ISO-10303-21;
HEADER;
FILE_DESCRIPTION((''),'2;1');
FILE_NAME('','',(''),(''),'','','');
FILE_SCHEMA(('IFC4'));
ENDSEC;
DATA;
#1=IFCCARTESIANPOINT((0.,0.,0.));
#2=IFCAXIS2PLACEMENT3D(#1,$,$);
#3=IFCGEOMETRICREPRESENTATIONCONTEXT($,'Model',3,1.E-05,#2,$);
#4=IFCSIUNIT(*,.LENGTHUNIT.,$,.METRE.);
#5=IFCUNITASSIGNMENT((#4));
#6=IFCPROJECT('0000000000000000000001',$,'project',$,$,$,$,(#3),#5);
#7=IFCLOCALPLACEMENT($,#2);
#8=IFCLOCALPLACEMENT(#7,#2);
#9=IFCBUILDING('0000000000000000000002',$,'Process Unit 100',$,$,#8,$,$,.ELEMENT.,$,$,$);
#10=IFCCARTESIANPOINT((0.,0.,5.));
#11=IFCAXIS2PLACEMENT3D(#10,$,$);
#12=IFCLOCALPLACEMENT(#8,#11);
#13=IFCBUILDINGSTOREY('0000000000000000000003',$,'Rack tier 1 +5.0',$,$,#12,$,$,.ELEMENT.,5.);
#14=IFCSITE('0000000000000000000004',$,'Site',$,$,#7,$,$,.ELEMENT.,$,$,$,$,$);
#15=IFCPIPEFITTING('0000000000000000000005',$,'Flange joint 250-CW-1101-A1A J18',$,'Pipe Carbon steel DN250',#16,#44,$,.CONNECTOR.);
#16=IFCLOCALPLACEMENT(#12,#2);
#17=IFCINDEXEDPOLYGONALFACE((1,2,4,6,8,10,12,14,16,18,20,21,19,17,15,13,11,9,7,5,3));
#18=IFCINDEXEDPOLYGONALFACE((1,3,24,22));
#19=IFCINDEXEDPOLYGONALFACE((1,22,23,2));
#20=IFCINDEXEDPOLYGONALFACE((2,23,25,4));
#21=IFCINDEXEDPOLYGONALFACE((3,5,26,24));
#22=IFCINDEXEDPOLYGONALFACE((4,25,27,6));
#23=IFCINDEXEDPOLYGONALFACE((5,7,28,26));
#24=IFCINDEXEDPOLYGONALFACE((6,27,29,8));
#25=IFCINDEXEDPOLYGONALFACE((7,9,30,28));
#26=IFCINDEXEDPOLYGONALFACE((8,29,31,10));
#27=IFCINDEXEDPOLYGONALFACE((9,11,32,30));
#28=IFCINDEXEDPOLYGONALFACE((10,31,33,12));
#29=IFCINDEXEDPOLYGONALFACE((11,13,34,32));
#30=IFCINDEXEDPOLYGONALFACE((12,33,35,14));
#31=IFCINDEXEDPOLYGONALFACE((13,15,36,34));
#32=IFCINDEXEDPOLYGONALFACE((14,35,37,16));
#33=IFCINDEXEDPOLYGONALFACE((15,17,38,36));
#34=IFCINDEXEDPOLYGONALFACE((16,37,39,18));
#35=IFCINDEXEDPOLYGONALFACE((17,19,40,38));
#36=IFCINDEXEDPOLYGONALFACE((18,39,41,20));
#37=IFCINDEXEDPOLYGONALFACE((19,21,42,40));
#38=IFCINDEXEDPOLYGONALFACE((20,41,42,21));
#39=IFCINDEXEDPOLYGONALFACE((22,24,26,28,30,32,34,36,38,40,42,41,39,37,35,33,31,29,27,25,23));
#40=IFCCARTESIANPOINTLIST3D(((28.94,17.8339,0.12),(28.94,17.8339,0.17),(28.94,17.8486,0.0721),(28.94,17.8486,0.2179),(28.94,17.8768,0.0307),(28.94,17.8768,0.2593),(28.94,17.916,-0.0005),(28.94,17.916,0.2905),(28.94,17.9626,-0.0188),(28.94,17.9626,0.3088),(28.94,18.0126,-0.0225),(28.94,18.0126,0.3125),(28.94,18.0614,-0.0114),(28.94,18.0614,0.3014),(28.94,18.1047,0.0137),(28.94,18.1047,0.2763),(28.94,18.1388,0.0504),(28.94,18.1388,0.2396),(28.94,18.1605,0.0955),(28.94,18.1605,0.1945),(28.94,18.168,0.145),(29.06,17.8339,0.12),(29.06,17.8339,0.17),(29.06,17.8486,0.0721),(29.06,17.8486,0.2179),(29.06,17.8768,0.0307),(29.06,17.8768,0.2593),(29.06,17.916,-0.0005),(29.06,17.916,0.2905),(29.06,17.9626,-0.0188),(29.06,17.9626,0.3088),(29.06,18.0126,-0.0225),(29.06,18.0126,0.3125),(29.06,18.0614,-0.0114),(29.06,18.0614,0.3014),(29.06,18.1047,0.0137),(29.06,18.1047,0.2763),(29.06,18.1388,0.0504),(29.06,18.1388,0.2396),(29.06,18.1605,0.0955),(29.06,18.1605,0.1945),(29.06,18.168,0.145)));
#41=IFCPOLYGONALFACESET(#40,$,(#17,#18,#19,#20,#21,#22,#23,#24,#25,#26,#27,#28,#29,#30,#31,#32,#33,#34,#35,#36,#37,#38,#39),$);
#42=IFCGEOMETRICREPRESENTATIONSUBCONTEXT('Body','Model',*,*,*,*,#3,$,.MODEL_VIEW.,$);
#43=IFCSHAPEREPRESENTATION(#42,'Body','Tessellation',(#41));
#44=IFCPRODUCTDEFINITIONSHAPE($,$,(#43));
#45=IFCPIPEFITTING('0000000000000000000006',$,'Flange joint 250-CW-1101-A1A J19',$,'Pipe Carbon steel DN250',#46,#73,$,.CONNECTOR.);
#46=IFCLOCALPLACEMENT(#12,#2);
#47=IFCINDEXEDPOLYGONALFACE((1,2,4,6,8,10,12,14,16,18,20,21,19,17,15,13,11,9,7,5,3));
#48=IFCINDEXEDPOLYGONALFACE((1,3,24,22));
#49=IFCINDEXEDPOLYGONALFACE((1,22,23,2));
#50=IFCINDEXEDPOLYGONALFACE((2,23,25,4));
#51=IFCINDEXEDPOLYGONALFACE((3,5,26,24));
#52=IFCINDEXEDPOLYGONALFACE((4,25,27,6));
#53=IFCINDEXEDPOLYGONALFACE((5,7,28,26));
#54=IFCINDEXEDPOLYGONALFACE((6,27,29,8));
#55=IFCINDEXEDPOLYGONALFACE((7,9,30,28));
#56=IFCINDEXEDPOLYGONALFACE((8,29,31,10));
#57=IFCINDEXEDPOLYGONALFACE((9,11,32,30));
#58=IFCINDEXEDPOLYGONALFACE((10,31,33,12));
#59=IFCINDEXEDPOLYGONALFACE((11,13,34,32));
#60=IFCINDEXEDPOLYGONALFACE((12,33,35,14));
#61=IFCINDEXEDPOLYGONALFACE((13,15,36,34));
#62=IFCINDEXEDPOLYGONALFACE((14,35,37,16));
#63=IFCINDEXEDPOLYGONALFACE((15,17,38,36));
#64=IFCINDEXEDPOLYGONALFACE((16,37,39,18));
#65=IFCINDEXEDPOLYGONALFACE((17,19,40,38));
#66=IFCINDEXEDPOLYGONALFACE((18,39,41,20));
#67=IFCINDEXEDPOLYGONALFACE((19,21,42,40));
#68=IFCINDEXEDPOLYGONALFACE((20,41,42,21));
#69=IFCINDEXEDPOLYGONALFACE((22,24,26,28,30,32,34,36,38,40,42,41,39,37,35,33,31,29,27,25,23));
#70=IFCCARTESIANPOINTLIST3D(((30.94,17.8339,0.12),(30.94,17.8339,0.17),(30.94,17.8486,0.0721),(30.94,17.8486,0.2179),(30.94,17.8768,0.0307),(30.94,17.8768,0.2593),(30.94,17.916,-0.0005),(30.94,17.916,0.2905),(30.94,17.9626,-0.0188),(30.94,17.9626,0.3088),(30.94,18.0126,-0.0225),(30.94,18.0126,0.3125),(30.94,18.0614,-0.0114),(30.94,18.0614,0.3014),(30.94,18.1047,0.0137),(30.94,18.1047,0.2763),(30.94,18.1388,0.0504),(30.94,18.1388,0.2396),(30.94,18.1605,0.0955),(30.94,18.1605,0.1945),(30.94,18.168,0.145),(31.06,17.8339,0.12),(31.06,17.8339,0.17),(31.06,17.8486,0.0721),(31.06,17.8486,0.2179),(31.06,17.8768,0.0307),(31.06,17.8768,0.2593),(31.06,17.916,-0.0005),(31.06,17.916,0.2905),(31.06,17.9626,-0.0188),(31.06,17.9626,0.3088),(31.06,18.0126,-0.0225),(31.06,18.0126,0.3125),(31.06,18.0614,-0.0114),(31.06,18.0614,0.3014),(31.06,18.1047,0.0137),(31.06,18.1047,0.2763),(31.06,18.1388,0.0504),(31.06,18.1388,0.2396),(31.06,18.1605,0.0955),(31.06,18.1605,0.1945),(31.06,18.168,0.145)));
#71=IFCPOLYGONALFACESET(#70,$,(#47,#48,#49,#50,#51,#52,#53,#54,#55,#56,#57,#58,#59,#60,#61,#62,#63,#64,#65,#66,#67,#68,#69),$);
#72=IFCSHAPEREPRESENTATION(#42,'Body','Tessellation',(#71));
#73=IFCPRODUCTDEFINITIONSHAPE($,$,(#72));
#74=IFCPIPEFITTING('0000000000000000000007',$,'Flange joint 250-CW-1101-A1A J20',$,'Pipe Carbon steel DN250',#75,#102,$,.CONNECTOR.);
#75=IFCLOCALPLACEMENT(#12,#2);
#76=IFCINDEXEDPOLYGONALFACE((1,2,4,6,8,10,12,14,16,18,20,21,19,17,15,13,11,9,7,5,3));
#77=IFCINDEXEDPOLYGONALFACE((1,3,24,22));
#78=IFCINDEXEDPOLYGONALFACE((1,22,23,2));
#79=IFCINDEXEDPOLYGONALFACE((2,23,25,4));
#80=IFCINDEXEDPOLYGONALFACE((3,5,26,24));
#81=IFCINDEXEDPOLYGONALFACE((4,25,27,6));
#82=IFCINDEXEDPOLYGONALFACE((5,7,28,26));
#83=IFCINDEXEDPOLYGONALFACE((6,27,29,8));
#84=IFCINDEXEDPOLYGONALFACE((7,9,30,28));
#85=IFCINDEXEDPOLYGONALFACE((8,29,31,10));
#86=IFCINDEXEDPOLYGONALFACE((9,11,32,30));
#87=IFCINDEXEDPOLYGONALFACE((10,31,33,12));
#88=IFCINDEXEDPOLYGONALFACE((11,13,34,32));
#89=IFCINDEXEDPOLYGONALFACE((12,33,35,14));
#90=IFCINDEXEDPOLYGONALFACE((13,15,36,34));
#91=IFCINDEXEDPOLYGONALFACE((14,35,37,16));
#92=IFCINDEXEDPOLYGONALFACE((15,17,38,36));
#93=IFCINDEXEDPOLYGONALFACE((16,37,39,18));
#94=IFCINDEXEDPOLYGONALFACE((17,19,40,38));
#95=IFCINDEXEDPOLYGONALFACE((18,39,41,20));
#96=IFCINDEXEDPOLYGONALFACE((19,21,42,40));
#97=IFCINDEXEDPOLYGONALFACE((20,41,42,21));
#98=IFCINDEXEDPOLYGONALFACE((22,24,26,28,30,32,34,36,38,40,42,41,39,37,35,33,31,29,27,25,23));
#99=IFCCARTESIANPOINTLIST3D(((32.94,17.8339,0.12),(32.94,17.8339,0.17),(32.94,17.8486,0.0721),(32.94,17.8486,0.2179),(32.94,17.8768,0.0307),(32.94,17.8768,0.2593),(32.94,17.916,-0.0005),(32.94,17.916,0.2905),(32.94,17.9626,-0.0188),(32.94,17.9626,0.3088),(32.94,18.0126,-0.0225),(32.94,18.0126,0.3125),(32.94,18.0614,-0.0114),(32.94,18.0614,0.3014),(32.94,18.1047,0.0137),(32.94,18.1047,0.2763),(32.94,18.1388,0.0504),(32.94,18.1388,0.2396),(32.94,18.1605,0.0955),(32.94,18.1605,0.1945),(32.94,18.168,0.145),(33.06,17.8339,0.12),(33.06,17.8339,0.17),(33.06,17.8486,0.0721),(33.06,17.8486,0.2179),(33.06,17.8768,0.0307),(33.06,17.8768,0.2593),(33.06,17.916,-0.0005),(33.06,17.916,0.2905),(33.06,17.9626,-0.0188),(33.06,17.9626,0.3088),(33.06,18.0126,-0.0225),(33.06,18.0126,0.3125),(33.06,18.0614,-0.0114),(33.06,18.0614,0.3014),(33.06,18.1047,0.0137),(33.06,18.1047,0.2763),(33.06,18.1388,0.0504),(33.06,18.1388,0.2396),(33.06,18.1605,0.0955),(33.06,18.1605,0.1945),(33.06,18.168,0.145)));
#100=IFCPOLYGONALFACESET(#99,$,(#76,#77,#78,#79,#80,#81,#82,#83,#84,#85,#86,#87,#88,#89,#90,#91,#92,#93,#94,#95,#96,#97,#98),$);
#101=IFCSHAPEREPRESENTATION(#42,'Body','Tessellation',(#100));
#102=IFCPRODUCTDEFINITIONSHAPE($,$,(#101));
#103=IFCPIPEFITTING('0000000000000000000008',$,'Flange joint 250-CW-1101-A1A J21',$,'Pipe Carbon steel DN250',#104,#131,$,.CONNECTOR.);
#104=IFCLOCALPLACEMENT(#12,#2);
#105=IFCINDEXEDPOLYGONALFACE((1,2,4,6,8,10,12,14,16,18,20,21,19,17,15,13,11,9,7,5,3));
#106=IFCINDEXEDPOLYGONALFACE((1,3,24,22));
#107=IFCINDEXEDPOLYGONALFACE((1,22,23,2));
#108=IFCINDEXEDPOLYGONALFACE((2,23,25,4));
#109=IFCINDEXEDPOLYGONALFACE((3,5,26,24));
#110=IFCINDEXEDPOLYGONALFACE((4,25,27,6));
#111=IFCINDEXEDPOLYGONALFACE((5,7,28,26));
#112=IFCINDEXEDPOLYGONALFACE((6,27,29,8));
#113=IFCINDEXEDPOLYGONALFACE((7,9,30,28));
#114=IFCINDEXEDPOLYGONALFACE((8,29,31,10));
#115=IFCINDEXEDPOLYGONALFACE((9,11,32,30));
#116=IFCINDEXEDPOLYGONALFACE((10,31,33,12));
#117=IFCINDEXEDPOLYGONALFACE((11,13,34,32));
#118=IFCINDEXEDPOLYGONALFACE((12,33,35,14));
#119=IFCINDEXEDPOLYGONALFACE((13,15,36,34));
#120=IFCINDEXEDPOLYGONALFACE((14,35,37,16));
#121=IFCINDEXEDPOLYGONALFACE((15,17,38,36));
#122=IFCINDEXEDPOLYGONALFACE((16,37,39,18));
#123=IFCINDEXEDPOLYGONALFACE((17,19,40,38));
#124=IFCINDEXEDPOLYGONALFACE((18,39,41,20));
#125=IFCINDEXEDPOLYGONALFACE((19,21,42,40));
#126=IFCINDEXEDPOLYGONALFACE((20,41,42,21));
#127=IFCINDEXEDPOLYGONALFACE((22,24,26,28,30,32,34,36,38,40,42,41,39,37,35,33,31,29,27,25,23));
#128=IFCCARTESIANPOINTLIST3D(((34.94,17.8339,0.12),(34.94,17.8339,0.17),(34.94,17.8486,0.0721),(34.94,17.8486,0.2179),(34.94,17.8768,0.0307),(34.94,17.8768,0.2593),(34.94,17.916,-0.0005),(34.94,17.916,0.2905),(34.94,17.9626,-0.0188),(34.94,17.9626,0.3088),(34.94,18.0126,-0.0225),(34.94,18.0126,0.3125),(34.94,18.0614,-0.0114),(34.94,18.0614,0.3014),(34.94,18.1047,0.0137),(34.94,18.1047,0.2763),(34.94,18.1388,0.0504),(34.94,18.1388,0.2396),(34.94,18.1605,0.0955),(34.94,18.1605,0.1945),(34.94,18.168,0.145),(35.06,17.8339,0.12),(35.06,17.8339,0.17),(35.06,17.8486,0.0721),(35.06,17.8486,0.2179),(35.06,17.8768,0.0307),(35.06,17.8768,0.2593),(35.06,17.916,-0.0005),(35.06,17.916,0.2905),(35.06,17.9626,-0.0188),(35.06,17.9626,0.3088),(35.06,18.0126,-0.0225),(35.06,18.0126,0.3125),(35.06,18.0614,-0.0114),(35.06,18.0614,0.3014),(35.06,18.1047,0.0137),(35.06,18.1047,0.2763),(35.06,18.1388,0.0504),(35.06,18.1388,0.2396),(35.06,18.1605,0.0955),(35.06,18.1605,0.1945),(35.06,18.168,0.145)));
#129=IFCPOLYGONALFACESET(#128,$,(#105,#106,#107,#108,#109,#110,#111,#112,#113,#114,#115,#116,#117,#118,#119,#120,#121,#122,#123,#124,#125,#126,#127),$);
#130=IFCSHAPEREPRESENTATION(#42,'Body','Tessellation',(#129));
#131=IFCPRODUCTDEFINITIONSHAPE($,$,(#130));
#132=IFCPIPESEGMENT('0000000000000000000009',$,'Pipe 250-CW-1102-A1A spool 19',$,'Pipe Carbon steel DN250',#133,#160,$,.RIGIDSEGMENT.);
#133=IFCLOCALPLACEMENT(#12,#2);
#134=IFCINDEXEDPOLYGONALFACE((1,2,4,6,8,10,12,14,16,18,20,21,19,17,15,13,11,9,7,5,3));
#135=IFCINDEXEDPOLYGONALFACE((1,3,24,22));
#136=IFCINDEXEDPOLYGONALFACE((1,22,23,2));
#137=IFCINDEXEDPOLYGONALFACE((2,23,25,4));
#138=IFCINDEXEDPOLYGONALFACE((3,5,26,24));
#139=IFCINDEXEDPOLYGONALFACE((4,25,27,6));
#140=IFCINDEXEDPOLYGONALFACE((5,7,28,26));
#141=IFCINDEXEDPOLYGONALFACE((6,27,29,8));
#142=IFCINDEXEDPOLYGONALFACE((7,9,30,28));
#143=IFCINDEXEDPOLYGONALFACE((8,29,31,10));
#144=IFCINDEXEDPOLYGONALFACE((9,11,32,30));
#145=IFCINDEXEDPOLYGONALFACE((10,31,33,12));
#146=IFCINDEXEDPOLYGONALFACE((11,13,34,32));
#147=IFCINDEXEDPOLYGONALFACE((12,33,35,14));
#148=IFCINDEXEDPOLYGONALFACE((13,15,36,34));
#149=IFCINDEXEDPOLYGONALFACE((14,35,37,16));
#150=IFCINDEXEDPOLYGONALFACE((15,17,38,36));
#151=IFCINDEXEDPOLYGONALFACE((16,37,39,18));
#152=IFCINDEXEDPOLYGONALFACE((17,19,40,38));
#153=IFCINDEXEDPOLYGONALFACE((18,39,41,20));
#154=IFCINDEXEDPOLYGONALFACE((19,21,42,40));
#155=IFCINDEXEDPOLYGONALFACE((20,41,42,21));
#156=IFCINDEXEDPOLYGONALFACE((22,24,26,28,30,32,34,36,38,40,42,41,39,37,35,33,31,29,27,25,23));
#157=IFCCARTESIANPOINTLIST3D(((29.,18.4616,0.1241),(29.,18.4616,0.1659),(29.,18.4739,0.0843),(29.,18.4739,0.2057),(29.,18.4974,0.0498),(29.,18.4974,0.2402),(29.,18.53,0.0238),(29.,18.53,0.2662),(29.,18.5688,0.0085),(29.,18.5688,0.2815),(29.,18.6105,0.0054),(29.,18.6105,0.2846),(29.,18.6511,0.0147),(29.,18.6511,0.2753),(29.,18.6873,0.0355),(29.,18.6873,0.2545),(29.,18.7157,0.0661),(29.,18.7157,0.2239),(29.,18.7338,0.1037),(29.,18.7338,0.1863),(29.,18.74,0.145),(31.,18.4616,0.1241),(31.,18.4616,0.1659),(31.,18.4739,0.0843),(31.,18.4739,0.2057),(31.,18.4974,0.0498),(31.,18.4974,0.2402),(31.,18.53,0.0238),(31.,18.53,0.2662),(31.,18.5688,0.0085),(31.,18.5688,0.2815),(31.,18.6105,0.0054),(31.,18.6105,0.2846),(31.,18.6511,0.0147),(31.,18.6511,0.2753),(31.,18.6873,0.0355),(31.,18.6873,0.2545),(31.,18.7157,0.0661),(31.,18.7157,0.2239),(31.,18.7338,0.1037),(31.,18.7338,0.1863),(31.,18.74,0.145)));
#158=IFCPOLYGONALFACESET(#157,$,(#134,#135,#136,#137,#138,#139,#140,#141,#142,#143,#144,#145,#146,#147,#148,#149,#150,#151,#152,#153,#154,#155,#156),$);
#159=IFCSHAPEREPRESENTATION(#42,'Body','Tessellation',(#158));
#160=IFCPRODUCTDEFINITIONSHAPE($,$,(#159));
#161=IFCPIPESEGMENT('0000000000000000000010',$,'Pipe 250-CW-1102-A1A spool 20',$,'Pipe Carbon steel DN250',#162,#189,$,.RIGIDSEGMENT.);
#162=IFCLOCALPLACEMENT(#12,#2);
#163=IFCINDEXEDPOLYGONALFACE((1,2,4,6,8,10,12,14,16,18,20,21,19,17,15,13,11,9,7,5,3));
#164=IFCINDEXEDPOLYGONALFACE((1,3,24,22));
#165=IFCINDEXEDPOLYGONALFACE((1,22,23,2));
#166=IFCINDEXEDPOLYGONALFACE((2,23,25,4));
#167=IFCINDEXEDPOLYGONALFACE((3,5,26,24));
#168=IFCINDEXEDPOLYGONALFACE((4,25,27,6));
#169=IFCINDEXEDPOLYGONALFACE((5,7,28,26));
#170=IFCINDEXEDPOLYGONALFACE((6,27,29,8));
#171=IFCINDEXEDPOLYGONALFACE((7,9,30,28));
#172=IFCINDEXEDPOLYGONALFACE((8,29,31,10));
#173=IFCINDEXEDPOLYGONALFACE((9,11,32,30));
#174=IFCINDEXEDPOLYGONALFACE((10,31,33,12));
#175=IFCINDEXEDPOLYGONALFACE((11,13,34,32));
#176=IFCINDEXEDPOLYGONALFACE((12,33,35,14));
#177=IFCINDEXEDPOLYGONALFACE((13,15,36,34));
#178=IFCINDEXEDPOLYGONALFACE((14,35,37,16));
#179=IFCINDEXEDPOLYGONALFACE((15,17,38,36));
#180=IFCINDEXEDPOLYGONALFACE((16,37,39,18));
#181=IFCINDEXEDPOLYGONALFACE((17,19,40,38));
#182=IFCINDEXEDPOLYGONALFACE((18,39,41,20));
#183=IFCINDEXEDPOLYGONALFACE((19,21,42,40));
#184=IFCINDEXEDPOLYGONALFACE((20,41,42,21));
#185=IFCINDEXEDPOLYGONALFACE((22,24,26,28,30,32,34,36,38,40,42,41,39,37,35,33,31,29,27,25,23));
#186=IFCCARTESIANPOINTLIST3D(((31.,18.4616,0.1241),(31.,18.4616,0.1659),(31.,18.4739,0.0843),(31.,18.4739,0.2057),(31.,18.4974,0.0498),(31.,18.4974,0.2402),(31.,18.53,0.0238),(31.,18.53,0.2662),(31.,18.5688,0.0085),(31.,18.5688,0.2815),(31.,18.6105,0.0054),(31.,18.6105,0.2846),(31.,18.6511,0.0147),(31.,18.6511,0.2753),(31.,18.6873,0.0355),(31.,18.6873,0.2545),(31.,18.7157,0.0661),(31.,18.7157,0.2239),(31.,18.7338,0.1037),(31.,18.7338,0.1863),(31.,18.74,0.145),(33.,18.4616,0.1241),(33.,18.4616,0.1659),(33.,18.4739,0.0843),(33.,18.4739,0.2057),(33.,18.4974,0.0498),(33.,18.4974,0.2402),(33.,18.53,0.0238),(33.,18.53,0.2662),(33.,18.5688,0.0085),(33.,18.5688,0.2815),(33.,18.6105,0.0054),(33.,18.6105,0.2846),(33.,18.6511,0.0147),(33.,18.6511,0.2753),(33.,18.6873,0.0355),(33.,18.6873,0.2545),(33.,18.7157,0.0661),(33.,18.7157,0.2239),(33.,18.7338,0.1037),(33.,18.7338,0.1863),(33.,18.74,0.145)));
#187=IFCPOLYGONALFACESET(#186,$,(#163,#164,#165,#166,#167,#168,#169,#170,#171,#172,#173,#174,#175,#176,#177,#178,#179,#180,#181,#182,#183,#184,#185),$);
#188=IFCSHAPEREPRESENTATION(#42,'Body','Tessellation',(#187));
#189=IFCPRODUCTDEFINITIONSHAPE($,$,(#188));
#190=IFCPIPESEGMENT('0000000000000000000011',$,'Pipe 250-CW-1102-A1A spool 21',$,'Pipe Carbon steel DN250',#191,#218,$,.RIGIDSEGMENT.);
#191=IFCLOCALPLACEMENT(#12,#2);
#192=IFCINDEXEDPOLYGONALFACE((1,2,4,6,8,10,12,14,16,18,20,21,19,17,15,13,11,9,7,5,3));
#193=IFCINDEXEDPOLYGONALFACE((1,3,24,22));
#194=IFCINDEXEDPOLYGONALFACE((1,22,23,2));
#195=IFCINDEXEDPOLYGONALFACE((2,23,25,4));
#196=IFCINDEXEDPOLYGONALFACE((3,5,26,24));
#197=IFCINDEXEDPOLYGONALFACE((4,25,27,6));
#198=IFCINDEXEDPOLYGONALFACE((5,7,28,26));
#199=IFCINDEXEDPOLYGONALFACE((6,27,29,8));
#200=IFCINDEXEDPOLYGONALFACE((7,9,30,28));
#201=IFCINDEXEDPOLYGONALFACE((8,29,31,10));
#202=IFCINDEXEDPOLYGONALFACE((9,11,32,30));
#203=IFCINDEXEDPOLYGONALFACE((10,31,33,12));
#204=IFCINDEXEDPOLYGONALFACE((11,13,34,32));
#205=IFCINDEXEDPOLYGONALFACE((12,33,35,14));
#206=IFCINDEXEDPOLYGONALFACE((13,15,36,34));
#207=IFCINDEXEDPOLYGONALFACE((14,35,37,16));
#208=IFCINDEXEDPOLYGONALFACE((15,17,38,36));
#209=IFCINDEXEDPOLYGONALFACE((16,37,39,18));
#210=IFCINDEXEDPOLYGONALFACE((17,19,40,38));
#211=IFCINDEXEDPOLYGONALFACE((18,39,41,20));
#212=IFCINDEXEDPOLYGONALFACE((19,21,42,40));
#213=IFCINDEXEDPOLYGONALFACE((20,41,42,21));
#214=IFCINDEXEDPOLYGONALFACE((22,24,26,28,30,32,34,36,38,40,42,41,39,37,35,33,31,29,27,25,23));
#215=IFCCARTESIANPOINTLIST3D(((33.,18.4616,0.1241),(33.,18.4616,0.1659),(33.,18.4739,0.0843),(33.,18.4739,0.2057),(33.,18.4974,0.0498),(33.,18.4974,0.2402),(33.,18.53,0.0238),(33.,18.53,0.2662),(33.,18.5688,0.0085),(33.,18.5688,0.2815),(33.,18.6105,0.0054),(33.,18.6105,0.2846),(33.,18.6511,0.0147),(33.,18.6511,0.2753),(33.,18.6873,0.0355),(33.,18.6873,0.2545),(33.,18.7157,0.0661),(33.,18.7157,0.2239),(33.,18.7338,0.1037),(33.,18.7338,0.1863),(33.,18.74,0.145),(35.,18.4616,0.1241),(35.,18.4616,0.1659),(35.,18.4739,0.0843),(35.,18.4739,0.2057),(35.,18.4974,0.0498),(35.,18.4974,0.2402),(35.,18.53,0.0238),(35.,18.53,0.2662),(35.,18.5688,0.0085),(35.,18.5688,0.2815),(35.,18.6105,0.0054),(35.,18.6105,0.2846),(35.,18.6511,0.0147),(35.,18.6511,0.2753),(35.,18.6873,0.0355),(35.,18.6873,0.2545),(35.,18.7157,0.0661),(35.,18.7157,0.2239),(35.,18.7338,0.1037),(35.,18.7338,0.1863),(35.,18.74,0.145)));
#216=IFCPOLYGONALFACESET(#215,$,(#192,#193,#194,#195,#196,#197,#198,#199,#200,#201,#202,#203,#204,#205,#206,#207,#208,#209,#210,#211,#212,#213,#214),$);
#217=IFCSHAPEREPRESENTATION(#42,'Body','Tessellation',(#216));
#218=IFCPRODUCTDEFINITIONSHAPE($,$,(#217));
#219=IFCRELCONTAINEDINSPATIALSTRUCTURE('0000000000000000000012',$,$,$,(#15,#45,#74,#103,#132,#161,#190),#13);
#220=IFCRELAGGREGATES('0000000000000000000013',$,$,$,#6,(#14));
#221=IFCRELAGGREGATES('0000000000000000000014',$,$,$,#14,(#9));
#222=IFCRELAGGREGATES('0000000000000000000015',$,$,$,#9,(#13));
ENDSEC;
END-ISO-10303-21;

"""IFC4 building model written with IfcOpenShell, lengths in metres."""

from ifc_helpers import new_model, si_unit, frame, origin, place, context, subcontext, project, spatial, circle, extrude, element, save


model = new_model("IFC4")

# Units and contexts
model_context = context("Model", 3, precision=1e-05, world=origin())
body_context = subcontext(model_context, "Body", "Model", "MODEL_VIEW")
ifc_project = project(units=[si_unit("LENGTHUNIT", "METRE")], contexts=[model_context])

# Site, building, storey
site_placement = place(None, origin())
site = spatial("IfcSite", under=ifc_project, at=site_placement, Name="Site", CompositionType="ELEMENT")
building_placement = place(site_placement, origin())
building = spatial("IfcBuilding", under=site, at=building_placement, Name="Process Unit 100", CompositionType="ELEMENT")
storey_placement = place(building_placement, frame((0.0, 0.0, 5.0)))
storey = spatial("IfcBuildingStorey", under=building, at=storey_placement, Name="Rack tier 1 +5.0", CompositionType="ELEMENT", Elevation=5.0)

# Pipe fittings
for number, where, z_axis, x_axis, name in (
    (1, (28.94, 18.0, 0.145), (1.0, 0.0, 0.0), (0.0, 1.0, 0.0), "Flange joint 250-CW-1101-A1A J18"),
    (2, (30.94, 18.0, 0.145), (1.0, 0.0, 0.0), (0.0, 1.0, 0.0), "Flange joint 250-CW-1101-A1A J19"),
    (3, (32.94, 18.0, 0.145), (1.0, 0.0, 0.0), (0.0, 1.0, 0.0), "Flange joint 250-CW-1101-A1A J20"),
    (4, (34.94, 18.0, 0.145), (1.0, 0.0, 0.0), (0.0, 1.0, 0.0), "Flange joint 250-CW-1101-A1A J21"),
):
    element("IfcPipeFitting", number, at=place(storey_placement, frame(where, z_axis=z_axis, x_axis=x_axis)), inside=storey, Name=name, ObjectType="Pipe Carbon steel DN250", PredefinedType="CONNECTOR", context=body_context, shape_type="SweptSolid", body=[
        extrude(circle(Radius=0.168), origin(), (0.0, 0.0, 1.0), 0.12),
    ])

# Pipe segments
for number, where, z_axis, x_axis, name in (
    (5, (29.0, 18.6, 0.145), (1.0, 0.0, 0.0), (0.0, 1.0, 0.0), "Pipe 250-CW-1102-A1A spool 19"),
    (6, (31.0, 18.6, 0.145), (1.0, 0.0, 0.0), (0.0, 1.0, 0.0), "Pipe 250-CW-1102-A1A spool 20"),
    (7, (33.0, 18.6, 0.145), (1.0, 0.0, 0.0), (0.0, 1.0, 0.0), "Pipe 250-CW-1102-A1A spool 21"),
):
    element("IfcPipeSegment", number, at=place(storey_placement, frame(where, z_axis=z_axis, x_axis=x_axis)), inside=storey, Name=name, ObjectType="Pipe Carbon steel DN250", PredefinedType="RIGIDSEGMENT", context=body_context, shape_type="SweptSolid", body=[
        extrude(circle(Radius=0.14), origin(), (0.0, 0.0, 1.0), 2.0),
    ])

save(model, "model.ifc")
